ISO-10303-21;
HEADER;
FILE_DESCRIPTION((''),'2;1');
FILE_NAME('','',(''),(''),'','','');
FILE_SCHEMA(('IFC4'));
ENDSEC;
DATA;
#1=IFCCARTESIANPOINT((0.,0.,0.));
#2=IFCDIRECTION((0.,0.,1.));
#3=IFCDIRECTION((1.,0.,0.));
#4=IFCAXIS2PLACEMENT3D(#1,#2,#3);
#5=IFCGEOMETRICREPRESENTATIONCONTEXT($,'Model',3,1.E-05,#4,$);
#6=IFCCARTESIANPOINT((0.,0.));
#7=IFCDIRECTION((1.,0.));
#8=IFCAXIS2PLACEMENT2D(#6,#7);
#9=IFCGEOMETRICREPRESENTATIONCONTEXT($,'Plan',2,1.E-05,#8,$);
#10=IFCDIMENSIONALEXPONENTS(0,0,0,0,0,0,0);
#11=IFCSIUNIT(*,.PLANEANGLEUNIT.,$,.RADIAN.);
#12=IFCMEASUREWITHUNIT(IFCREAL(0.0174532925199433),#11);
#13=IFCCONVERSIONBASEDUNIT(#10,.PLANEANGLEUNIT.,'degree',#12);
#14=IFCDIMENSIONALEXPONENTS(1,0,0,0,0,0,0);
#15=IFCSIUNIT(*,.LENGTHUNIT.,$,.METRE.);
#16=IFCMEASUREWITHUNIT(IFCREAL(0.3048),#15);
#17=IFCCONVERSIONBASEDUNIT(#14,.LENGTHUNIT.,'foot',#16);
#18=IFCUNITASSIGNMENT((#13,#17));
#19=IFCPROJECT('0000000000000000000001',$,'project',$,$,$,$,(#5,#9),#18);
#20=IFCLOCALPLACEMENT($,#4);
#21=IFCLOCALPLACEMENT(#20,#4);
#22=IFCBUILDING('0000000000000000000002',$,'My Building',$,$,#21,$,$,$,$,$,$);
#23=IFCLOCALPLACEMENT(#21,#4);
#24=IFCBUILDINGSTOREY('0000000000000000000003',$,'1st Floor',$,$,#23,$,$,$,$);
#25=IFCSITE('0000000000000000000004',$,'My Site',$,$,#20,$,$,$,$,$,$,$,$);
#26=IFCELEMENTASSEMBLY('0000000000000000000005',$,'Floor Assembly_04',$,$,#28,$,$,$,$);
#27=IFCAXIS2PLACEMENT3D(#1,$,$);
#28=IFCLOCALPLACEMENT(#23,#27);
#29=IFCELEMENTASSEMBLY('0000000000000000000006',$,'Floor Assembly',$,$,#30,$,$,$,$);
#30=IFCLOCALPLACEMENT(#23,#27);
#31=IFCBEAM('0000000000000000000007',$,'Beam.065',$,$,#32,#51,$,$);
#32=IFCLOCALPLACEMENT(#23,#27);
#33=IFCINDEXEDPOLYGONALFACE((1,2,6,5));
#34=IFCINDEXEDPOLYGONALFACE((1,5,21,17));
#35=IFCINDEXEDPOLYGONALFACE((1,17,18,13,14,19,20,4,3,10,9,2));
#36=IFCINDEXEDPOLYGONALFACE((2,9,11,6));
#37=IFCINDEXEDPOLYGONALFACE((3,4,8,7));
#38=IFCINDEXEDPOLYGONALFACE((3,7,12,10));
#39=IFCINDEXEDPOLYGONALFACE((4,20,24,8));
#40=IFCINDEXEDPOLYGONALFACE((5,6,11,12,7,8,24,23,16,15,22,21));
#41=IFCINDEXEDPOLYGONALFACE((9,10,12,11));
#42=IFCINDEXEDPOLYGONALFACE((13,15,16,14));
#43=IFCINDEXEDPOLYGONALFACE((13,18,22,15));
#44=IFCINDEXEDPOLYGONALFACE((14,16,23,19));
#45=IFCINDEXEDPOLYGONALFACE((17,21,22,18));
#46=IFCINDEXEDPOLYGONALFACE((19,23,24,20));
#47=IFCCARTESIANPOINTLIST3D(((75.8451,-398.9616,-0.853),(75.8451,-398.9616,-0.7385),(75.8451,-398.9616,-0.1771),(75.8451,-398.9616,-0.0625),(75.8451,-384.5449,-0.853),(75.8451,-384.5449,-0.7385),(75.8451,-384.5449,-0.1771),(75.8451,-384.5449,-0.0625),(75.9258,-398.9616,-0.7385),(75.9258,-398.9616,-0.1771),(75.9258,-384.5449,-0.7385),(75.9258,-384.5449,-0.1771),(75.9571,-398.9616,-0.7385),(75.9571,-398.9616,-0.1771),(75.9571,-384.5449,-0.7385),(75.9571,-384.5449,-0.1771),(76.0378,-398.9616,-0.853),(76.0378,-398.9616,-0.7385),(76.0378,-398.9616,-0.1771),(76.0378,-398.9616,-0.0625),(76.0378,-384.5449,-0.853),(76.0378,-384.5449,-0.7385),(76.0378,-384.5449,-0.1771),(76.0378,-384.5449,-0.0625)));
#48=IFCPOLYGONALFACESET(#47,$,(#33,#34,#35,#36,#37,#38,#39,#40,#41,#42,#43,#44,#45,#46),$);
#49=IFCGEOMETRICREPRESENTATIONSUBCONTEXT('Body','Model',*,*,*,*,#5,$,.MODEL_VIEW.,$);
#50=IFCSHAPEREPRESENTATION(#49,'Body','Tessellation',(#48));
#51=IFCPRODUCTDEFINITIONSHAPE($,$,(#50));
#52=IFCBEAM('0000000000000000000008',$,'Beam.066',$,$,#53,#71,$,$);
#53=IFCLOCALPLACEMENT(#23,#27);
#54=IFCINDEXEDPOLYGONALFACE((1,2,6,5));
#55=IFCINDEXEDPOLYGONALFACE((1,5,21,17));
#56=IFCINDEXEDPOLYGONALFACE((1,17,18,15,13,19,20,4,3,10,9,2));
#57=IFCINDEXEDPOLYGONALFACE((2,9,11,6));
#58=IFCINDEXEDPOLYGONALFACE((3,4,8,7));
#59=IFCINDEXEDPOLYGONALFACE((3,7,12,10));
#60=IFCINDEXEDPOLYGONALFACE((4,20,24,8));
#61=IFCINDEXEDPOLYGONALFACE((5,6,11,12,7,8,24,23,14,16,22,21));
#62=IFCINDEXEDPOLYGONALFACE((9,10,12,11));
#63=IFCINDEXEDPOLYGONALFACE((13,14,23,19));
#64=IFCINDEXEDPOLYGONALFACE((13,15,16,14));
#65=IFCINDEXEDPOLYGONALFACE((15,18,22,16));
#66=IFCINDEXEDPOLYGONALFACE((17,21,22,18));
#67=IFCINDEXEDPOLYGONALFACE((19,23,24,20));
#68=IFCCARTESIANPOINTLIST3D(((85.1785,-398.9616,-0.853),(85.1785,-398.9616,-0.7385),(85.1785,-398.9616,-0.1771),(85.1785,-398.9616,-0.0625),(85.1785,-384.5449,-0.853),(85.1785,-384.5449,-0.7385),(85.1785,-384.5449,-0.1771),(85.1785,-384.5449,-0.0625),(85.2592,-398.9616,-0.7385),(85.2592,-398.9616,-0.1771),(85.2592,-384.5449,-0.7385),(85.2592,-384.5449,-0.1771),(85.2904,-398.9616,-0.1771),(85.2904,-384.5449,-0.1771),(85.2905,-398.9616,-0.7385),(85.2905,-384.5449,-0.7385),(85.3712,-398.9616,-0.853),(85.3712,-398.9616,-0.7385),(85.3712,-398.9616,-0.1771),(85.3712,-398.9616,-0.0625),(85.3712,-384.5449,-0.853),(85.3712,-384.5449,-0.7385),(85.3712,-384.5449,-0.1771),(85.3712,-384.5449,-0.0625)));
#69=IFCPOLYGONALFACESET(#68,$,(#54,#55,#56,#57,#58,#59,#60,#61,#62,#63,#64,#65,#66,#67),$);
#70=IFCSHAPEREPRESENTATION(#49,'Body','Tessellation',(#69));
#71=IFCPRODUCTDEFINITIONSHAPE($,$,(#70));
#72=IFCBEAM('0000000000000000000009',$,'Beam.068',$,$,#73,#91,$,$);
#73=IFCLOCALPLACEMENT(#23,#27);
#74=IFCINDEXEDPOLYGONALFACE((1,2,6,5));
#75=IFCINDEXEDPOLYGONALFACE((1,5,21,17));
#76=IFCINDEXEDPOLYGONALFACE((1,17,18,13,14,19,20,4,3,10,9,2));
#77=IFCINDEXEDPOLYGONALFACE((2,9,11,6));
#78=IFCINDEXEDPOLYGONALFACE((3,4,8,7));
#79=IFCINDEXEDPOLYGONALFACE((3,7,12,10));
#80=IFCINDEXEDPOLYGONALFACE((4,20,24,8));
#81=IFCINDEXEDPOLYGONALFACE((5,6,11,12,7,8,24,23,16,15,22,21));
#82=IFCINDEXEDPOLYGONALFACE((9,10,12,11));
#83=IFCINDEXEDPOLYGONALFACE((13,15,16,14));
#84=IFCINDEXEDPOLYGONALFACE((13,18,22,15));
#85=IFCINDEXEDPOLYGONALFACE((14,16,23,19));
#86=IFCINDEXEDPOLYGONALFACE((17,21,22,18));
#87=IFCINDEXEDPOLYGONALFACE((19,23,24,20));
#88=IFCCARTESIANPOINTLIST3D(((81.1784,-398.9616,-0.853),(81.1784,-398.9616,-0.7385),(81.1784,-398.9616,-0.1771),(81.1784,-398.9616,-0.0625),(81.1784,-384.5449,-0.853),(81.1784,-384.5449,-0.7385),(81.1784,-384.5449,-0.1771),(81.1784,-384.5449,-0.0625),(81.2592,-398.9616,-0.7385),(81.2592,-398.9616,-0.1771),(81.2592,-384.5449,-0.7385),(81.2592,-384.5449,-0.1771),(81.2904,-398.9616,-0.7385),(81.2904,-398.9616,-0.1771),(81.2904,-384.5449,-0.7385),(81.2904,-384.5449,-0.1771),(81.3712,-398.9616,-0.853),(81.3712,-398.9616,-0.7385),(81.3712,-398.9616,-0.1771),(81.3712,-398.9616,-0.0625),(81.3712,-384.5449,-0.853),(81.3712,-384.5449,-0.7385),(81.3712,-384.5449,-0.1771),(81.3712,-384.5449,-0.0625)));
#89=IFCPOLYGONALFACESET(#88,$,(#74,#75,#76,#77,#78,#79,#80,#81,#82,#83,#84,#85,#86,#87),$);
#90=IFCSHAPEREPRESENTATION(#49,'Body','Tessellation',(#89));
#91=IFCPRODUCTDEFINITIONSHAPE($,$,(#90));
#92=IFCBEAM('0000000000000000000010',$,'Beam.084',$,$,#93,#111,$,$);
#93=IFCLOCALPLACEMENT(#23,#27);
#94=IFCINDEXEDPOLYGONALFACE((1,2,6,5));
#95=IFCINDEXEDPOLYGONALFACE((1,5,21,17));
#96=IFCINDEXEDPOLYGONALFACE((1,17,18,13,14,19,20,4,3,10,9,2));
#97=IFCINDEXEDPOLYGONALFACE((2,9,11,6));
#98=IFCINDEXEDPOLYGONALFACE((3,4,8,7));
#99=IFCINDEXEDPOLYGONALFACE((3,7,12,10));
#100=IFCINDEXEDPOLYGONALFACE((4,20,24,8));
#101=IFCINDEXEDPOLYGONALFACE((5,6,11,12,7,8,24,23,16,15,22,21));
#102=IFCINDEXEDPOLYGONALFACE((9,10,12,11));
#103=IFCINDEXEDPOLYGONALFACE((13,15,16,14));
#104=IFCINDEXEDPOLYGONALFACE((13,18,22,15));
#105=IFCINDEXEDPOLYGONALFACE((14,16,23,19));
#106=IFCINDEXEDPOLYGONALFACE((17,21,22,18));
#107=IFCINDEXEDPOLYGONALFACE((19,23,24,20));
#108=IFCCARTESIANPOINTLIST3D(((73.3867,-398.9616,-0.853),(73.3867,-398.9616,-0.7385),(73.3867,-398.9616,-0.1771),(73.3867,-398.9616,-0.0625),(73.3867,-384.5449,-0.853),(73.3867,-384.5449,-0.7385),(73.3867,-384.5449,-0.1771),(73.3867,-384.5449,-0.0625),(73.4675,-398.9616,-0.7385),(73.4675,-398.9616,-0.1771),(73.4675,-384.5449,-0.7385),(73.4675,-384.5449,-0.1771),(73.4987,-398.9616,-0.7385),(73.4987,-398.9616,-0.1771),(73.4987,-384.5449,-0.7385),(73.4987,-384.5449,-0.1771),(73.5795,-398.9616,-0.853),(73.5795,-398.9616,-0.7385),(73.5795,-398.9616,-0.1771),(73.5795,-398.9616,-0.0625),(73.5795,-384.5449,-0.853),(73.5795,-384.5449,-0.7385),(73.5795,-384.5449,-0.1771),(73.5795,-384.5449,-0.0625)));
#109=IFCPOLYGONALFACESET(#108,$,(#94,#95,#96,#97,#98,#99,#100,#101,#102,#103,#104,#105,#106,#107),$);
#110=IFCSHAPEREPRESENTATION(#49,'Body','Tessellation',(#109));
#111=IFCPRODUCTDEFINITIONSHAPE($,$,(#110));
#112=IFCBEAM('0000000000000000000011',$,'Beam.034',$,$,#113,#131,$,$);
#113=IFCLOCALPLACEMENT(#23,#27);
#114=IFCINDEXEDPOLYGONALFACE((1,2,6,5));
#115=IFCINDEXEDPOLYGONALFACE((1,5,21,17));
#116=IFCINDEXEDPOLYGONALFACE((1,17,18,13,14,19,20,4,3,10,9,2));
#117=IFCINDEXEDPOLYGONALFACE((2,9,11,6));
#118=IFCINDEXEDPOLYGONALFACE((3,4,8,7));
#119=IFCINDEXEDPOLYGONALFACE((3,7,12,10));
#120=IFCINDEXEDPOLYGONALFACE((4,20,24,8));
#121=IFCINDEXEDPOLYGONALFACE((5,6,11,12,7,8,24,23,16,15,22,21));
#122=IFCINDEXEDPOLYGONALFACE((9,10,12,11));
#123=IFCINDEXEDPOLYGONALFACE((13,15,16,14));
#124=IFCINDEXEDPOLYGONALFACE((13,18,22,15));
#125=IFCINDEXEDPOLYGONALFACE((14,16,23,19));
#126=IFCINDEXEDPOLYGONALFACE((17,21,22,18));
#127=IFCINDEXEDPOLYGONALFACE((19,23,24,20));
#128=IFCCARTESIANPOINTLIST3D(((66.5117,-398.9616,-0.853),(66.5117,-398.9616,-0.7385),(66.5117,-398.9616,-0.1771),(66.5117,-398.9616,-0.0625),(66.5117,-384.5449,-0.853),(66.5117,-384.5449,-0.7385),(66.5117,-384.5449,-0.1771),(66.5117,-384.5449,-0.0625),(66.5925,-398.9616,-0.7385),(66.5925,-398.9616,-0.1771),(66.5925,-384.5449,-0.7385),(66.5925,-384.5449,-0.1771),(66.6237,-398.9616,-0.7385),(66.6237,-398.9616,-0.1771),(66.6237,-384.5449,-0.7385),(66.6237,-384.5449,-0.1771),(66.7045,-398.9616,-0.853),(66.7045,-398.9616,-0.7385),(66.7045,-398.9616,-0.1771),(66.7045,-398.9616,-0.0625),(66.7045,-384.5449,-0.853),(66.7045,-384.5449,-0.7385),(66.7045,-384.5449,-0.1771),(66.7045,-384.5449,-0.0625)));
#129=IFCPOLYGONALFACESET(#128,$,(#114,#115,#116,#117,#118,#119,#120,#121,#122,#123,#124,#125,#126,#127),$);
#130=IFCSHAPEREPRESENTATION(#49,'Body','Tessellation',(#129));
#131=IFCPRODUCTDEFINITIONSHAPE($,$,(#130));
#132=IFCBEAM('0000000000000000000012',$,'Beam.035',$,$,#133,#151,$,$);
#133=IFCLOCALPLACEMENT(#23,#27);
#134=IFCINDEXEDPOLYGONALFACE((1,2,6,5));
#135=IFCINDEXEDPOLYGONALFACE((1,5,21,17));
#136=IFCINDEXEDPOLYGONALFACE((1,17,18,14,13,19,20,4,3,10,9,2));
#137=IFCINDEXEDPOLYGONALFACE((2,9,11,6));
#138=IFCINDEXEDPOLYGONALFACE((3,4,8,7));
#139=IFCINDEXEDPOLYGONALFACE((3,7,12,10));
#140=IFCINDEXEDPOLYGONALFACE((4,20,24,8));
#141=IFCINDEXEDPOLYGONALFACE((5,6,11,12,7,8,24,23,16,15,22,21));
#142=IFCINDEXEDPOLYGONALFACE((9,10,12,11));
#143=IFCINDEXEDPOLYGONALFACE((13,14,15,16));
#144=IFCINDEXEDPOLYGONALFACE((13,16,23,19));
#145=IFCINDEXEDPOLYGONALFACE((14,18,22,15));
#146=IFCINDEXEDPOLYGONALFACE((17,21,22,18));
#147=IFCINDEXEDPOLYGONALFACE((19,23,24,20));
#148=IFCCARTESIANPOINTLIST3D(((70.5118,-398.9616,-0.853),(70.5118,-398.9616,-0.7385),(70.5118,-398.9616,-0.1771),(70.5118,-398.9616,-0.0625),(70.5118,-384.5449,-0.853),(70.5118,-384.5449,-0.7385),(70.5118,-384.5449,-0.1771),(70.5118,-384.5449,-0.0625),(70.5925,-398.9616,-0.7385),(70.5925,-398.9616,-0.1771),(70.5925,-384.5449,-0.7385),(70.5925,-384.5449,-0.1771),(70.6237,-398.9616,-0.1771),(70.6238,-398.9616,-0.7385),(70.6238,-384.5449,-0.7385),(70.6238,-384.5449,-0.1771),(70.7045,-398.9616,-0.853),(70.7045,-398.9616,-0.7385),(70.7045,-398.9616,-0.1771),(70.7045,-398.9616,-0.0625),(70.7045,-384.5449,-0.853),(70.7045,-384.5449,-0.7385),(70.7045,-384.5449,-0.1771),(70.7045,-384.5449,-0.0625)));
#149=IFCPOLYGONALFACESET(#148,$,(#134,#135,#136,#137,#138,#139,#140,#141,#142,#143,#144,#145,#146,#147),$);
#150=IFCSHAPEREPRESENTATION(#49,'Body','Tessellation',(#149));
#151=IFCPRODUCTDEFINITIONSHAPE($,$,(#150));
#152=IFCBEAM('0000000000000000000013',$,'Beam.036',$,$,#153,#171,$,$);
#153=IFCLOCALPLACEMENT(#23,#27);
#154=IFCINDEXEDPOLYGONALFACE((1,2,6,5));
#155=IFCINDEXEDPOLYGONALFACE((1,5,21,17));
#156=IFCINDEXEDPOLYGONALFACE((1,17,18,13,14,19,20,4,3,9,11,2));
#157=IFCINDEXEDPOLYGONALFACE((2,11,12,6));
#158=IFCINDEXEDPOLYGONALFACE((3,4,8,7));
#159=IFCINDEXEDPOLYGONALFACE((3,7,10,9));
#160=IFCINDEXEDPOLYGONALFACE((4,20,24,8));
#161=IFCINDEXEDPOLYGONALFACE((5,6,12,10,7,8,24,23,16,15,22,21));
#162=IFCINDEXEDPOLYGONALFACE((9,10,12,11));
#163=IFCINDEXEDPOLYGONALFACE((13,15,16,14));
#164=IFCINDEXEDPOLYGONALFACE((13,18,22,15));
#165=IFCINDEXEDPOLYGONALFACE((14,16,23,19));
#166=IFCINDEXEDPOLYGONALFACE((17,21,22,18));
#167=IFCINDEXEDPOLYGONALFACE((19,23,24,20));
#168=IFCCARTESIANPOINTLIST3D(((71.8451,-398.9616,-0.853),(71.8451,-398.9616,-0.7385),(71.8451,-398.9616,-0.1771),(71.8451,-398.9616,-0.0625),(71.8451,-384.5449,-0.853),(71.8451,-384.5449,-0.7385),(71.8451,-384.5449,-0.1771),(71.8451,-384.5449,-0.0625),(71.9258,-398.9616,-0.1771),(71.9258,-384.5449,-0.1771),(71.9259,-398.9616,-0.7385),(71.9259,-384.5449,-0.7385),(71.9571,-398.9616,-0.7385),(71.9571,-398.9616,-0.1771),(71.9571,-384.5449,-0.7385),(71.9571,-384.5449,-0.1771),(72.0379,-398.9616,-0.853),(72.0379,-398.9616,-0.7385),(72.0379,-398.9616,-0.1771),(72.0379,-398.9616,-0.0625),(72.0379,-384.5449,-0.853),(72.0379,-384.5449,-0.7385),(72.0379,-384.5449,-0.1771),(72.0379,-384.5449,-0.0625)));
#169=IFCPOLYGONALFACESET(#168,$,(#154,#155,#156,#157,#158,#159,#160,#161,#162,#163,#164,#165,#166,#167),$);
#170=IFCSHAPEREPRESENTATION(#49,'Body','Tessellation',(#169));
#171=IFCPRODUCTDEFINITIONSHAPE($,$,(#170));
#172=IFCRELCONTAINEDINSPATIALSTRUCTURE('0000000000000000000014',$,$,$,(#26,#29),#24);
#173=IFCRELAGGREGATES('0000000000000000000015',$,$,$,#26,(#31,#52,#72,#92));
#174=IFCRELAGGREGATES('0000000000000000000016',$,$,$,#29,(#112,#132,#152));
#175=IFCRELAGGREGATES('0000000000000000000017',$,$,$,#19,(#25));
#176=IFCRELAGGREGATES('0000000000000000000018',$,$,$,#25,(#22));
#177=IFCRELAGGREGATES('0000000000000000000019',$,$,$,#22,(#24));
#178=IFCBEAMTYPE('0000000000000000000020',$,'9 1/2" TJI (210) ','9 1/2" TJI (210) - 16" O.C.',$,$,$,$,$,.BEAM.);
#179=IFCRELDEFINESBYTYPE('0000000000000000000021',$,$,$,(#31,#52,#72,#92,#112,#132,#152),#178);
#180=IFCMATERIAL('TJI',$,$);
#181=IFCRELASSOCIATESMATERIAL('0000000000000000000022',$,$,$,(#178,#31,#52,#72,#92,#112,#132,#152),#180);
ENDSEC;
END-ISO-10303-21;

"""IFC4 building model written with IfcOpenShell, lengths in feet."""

from ifc_helpers import new_model, entity, si_unit, converted_unit, frame, origin_with_axes, origin_2d_with_axis, place, context, subcontext, project, spatial, indexed_curve, outline, extrude, material, material_profile, profile_set, profile_usage, type_object, element, aggregate, save


model = new_model("IFC4")

# Units and contexts
model_context = context("Model", 3, precision=1e-05, world=origin_with_axes())
plan_context = context("Plan", 2, precision=1e-05, world=origin_2d_with_axis())
body_context = subcontext(model_context, "Body", "Model", "MODEL_VIEW")
ifc_project = project(units=[converted_unit("PLANEANGLEUNIT", "degree", entity("IfcReal", 0.0174532925199433), si_unit("PLANEANGLEUNIT", "RADIAN"), dimensions=[0, 0, 0, 0, 0, 0, 0]), converted_unit("LENGTHUNIT", "foot", entity("IfcReal", 0.3048), si_unit("LENGTHUNIT", "METRE"), dimensions=[1, 0, 0, 0, 0, 0, 0])], contexts=[model_context, plan_context])

# Site, building, storey
site_placement = place(None, origin_with_axes())
site = spatial("IfcSite", under=ifc_project, at=site_placement, Name="My Site")
building_placement = place(site_placement, origin_with_axes())
building = spatial("IfcBuilding", under=site, at=building_placement, Name="My Building")
storey_placement = place(building_placement, origin_with_axes())
storey = spatial("IfcBuildingStorey", under=building, at=storey_placement, Name="1st Floor")

# Element assemblies
assembly_1_placement = place(storey_placement, frame((73.1784, -398.9616, -0.0625), z_axis=(0.0, 0.0, 1.0), x_axis=(0.0, 1.0, 0.0)))
assembly_1 = element("IfcElementAssembly", 1, at=assembly_1_placement, inside=storey, Name="Floor Assembly_04")
assembly_2_placement = place(storey_placement, frame((61.1784, -398.9616, -0.0625), z_axis=(0.0, 0.0, 1.0), x_axis=(0.0, 1.0, 0.0)))
assembly_2 = element("IfcElementAssembly", 2, at=assembly_2_placement, inside=storey, Name="Floor Assembly")

# Beams
ifc_material_1 = material(Name="TJI")
ifc_material_profile_1 = material_profile(ifc_material_1, outline(indexed_curve([(0.0964, 0.7905), (-0.0964, 0.7905), (-0.0964, 0.6759), (-0.0156, 0.6759), (-0.0156, 0.1146), (-0.0964, 0.1146), (-0.0964, 0.0), (0.0964, 0.0), (0.0964, 0.1146), (0.0156, 0.1146), (0.0157, 0.6759), (0.0964, 0.6759), (0.0964, 0.7905)])))
ifc_profile_set_1 = profile_set([ifc_material_profile_1])
beam_type_1 = type_object("IfcBeamType", Name="9 1/2\" TJI (210) ", Description="9 1/2\" TJI (210) - 16\" O.C.", PredefinedType="BEAM", material=ifc_profile_set_1)
ifc_profile_usage_1 = profile_usage(ifc_profile_set_1, cardinal=5)
beam_1_placement = place(assembly_1_placement, frame((0.0, -2.763, -0.7905), z_axis=(1.0, 0.0, 0.0), x_axis=(0.0, 1.0, 0.0)))
beam_1 = element("IfcBeam", 3, at=beam_1_placement, type_object=beam_type_1, material=ifc_profile_usage_1, Name="Beam.065", context=body_context, shape_type="SweptSolid", body=[
    extrude(outline(indexed_curve([(0.0964, 0.7905), (-0.0964, 0.7905), (-0.0964, 0.6759), (-0.0156, 0.6759), (-0.0156, 0.1146), (-0.0964, 0.1146), (-0.0964, 0.0), (0.0964, 0.0), (0.0964, 0.1146), (0.0156, 0.1146), (0.0157, 0.6759), (0.0964, 0.6759), (0.0964, 0.7905)])), origin_with_axes(), (0.0, 0.0, 1.0), 14.4167),
])
ifc_profile_usage_2 = profile_usage(ifc_profile_set_1, cardinal=5)
beam_2_placement = place(assembly_1_placement, frame((0.0, -12.0964, -0.7905), z_axis=(1.0, 0.0, 0.0), x_axis=(0.0, 1.0, 0.0)))
beam_2 = element("IfcBeam", 4, at=beam_2_placement, type_object=beam_type_1, material=ifc_profile_usage_2, Name="Beam.066", context=body_context, shape_type="SweptSolid", body=[
    extrude(outline(indexed_curve([(0.0964, 0.7905), (-0.0964, 0.7905), (-0.0964, 0.6759), (-0.0156, 0.6759), (-0.0156, 0.1146), (-0.0964, 0.1146), (-0.0964, 0.0), (0.0964, 0.0), (0.0964, 0.1146), (0.0156, 0.1146), (0.0157, 0.6759), (0.0964, 0.6759), (0.0964, 0.7905)])), origin_with_axes(), (0.0, 0.0, 1.0), 14.4167),
])
ifc_profile_usage_3 = profile_usage(ifc_profile_set_1, cardinal=5)
beam_3_placement = place(assembly_1_placement, frame((0.0, -8.0964, -0.7905), z_axis=(1.0, 0.0, 0.0), x_axis=(0.0, 1.0, 0.0)))
beam_3 = element("IfcBeam", 5, at=beam_3_placement, type_object=beam_type_1, material=ifc_profile_usage_3, Name="Beam.068", context=body_context, shape_type="SweptSolid", body=[
    extrude(outline(indexed_curve([(0.0964, 0.7905), (-0.0964, 0.7905), (-0.0964, 0.6759), (-0.0156, 0.6759), (-0.0156, 0.1146), (-0.0964, 0.1146), (-0.0964, 0.0), (0.0964, 0.0), (0.0964, 0.1146), (0.0156, 0.1146), (0.0157, 0.6759), (0.0964, 0.6759), (0.0964, 0.7905)])), origin_with_axes(), (0.0, 0.0, 1.0), 14.4167),
])
ifc_profile_usage_4 = profile_usage(ifc_profile_set_1, cardinal=5)
beam_4_placement = place(assembly_1_placement, frame((0.0, -0.3047, -0.7905), z_axis=(1.0, 0.0, 0.0), x_axis=(0.0, 1.0, 0.0)))
beam_4 = element("IfcBeam", 6, at=beam_4_placement, type_object=beam_type_1, material=ifc_profile_usage_4, Name="Beam.084", context=body_context, shape_type="SweptSolid", body=[
    extrude(outline(indexed_curve([(0.0964, 0.7905), (-0.0964, 0.7905), (-0.0964, 0.6759), (-0.0156, 0.6759), (-0.0156, 0.1146), (-0.0964, 0.1146), (-0.0964, 0.0), (0.0964, 0.0), (0.0964, 0.1146), (0.0156, 0.1146), (0.0157, 0.6759), (0.0964, 0.6759), (0.0964, 0.7905)])), origin_with_axes(), (0.0, 0.0, 1.0), 14.4167),
])
aggregate(assembly_1, [beam_1, beam_2, beam_3, beam_4])
ifc_profile_usage_5 = profile_usage(ifc_profile_set_1, cardinal=5)
beam_5_placement = place(assembly_2_placement, frame((0.0, -5.4297, -0.7905), z_axis=(1.0, 0.0, 0.0), x_axis=(0.0, 1.0, 0.0)))
beam_5 = element("IfcBeam", 7, at=beam_5_placement, type_object=beam_type_1, material=ifc_profile_usage_5, Name="Beam.034", context=body_context, shape_type="SweptSolid", body=[
    extrude(outline(indexed_curve([(0.0964, 0.7905), (-0.0964, 0.7905), (-0.0964, 0.6759), (-0.0156, 0.6759), (-0.0156, 0.1146), (-0.0964, 0.1146), (-0.0964, 0.0), (0.0964, 0.0), (0.0964, 0.1146), (0.0156, 0.1146), (0.0157, 0.6759), (0.0964, 0.6759), (0.0964, 0.7905)])), origin_with_axes(), (0.0, 0.0, 1.0), 14.4167),
])
ifc_profile_usage_6 = profile_usage(ifc_profile_set_1, cardinal=5)
beam_6_placement = place(assembly_2_placement, frame((0.0, -9.4297, -0.7905), z_axis=(1.0, 0.0, 0.0), x_axis=(0.0, 1.0, 0.0)))
beam_6 = element("IfcBeam", 8, at=beam_6_placement, type_object=beam_type_1, material=ifc_profile_usage_6, Name="Beam.035", context=body_context, shape_type="SweptSolid", body=[
    extrude(outline(indexed_curve([(0.0964, 0.7905), (-0.0964, 0.7905), (-0.0964, 0.6759), (-0.0156, 0.6759), (-0.0156, 0.1146), (-0.0964, 0.1146), (-0.0964, 0.0), (0.0964, 0.0), (0.0964, 0.1146), (0.0156, 0.1146), (0.0157, 0.6759), (0.0964, 0.6759), (0.0964, 0.7905)])), origin_with_axes(), (0.0, 0.0, 1.0), 14.4167),
])
ifc_profile_usage_7 = profile_usage(ifc_profile_set_1, cardinal=5)
beam_7_placement = place(assembly_2_placement, frame((0.0, -10.763, -0.7905), z_axis=(1.0, 0.0, 0.0), x_axis=(0.0, 1.0, 0.0)))
beam_7 = element("IfcBeam", 9, at=beam_7_placement, type_object=beam_type_1, material=ifc_profile_usage_7, Name="Beam.036", context=body_context, shape_type="SweptSolid", body=[
    extrude(outline(indexed_curve([(0.0964, 0.7905), (-0.0964, 0.7905), (-0.0964, 0.6759), (-0.0156, 0.6759), (-0.0156, 0.1146), (-0.0964, 0.1146), (-0.0964, 0.0), (0.0964, 0.0), (0.0964, 0.1146), (0.0156, 0.1146), (0.0157, 0.6759), (0.0964, 0.6759), (0.0964, 0.7905)])), origin_with_axes(), (0.0, 0.0, 1.0), 14.4167),
])
aggregate(assembly_2, [beam_5, beam_6, beam_7])

save(model, "model.ifc")
